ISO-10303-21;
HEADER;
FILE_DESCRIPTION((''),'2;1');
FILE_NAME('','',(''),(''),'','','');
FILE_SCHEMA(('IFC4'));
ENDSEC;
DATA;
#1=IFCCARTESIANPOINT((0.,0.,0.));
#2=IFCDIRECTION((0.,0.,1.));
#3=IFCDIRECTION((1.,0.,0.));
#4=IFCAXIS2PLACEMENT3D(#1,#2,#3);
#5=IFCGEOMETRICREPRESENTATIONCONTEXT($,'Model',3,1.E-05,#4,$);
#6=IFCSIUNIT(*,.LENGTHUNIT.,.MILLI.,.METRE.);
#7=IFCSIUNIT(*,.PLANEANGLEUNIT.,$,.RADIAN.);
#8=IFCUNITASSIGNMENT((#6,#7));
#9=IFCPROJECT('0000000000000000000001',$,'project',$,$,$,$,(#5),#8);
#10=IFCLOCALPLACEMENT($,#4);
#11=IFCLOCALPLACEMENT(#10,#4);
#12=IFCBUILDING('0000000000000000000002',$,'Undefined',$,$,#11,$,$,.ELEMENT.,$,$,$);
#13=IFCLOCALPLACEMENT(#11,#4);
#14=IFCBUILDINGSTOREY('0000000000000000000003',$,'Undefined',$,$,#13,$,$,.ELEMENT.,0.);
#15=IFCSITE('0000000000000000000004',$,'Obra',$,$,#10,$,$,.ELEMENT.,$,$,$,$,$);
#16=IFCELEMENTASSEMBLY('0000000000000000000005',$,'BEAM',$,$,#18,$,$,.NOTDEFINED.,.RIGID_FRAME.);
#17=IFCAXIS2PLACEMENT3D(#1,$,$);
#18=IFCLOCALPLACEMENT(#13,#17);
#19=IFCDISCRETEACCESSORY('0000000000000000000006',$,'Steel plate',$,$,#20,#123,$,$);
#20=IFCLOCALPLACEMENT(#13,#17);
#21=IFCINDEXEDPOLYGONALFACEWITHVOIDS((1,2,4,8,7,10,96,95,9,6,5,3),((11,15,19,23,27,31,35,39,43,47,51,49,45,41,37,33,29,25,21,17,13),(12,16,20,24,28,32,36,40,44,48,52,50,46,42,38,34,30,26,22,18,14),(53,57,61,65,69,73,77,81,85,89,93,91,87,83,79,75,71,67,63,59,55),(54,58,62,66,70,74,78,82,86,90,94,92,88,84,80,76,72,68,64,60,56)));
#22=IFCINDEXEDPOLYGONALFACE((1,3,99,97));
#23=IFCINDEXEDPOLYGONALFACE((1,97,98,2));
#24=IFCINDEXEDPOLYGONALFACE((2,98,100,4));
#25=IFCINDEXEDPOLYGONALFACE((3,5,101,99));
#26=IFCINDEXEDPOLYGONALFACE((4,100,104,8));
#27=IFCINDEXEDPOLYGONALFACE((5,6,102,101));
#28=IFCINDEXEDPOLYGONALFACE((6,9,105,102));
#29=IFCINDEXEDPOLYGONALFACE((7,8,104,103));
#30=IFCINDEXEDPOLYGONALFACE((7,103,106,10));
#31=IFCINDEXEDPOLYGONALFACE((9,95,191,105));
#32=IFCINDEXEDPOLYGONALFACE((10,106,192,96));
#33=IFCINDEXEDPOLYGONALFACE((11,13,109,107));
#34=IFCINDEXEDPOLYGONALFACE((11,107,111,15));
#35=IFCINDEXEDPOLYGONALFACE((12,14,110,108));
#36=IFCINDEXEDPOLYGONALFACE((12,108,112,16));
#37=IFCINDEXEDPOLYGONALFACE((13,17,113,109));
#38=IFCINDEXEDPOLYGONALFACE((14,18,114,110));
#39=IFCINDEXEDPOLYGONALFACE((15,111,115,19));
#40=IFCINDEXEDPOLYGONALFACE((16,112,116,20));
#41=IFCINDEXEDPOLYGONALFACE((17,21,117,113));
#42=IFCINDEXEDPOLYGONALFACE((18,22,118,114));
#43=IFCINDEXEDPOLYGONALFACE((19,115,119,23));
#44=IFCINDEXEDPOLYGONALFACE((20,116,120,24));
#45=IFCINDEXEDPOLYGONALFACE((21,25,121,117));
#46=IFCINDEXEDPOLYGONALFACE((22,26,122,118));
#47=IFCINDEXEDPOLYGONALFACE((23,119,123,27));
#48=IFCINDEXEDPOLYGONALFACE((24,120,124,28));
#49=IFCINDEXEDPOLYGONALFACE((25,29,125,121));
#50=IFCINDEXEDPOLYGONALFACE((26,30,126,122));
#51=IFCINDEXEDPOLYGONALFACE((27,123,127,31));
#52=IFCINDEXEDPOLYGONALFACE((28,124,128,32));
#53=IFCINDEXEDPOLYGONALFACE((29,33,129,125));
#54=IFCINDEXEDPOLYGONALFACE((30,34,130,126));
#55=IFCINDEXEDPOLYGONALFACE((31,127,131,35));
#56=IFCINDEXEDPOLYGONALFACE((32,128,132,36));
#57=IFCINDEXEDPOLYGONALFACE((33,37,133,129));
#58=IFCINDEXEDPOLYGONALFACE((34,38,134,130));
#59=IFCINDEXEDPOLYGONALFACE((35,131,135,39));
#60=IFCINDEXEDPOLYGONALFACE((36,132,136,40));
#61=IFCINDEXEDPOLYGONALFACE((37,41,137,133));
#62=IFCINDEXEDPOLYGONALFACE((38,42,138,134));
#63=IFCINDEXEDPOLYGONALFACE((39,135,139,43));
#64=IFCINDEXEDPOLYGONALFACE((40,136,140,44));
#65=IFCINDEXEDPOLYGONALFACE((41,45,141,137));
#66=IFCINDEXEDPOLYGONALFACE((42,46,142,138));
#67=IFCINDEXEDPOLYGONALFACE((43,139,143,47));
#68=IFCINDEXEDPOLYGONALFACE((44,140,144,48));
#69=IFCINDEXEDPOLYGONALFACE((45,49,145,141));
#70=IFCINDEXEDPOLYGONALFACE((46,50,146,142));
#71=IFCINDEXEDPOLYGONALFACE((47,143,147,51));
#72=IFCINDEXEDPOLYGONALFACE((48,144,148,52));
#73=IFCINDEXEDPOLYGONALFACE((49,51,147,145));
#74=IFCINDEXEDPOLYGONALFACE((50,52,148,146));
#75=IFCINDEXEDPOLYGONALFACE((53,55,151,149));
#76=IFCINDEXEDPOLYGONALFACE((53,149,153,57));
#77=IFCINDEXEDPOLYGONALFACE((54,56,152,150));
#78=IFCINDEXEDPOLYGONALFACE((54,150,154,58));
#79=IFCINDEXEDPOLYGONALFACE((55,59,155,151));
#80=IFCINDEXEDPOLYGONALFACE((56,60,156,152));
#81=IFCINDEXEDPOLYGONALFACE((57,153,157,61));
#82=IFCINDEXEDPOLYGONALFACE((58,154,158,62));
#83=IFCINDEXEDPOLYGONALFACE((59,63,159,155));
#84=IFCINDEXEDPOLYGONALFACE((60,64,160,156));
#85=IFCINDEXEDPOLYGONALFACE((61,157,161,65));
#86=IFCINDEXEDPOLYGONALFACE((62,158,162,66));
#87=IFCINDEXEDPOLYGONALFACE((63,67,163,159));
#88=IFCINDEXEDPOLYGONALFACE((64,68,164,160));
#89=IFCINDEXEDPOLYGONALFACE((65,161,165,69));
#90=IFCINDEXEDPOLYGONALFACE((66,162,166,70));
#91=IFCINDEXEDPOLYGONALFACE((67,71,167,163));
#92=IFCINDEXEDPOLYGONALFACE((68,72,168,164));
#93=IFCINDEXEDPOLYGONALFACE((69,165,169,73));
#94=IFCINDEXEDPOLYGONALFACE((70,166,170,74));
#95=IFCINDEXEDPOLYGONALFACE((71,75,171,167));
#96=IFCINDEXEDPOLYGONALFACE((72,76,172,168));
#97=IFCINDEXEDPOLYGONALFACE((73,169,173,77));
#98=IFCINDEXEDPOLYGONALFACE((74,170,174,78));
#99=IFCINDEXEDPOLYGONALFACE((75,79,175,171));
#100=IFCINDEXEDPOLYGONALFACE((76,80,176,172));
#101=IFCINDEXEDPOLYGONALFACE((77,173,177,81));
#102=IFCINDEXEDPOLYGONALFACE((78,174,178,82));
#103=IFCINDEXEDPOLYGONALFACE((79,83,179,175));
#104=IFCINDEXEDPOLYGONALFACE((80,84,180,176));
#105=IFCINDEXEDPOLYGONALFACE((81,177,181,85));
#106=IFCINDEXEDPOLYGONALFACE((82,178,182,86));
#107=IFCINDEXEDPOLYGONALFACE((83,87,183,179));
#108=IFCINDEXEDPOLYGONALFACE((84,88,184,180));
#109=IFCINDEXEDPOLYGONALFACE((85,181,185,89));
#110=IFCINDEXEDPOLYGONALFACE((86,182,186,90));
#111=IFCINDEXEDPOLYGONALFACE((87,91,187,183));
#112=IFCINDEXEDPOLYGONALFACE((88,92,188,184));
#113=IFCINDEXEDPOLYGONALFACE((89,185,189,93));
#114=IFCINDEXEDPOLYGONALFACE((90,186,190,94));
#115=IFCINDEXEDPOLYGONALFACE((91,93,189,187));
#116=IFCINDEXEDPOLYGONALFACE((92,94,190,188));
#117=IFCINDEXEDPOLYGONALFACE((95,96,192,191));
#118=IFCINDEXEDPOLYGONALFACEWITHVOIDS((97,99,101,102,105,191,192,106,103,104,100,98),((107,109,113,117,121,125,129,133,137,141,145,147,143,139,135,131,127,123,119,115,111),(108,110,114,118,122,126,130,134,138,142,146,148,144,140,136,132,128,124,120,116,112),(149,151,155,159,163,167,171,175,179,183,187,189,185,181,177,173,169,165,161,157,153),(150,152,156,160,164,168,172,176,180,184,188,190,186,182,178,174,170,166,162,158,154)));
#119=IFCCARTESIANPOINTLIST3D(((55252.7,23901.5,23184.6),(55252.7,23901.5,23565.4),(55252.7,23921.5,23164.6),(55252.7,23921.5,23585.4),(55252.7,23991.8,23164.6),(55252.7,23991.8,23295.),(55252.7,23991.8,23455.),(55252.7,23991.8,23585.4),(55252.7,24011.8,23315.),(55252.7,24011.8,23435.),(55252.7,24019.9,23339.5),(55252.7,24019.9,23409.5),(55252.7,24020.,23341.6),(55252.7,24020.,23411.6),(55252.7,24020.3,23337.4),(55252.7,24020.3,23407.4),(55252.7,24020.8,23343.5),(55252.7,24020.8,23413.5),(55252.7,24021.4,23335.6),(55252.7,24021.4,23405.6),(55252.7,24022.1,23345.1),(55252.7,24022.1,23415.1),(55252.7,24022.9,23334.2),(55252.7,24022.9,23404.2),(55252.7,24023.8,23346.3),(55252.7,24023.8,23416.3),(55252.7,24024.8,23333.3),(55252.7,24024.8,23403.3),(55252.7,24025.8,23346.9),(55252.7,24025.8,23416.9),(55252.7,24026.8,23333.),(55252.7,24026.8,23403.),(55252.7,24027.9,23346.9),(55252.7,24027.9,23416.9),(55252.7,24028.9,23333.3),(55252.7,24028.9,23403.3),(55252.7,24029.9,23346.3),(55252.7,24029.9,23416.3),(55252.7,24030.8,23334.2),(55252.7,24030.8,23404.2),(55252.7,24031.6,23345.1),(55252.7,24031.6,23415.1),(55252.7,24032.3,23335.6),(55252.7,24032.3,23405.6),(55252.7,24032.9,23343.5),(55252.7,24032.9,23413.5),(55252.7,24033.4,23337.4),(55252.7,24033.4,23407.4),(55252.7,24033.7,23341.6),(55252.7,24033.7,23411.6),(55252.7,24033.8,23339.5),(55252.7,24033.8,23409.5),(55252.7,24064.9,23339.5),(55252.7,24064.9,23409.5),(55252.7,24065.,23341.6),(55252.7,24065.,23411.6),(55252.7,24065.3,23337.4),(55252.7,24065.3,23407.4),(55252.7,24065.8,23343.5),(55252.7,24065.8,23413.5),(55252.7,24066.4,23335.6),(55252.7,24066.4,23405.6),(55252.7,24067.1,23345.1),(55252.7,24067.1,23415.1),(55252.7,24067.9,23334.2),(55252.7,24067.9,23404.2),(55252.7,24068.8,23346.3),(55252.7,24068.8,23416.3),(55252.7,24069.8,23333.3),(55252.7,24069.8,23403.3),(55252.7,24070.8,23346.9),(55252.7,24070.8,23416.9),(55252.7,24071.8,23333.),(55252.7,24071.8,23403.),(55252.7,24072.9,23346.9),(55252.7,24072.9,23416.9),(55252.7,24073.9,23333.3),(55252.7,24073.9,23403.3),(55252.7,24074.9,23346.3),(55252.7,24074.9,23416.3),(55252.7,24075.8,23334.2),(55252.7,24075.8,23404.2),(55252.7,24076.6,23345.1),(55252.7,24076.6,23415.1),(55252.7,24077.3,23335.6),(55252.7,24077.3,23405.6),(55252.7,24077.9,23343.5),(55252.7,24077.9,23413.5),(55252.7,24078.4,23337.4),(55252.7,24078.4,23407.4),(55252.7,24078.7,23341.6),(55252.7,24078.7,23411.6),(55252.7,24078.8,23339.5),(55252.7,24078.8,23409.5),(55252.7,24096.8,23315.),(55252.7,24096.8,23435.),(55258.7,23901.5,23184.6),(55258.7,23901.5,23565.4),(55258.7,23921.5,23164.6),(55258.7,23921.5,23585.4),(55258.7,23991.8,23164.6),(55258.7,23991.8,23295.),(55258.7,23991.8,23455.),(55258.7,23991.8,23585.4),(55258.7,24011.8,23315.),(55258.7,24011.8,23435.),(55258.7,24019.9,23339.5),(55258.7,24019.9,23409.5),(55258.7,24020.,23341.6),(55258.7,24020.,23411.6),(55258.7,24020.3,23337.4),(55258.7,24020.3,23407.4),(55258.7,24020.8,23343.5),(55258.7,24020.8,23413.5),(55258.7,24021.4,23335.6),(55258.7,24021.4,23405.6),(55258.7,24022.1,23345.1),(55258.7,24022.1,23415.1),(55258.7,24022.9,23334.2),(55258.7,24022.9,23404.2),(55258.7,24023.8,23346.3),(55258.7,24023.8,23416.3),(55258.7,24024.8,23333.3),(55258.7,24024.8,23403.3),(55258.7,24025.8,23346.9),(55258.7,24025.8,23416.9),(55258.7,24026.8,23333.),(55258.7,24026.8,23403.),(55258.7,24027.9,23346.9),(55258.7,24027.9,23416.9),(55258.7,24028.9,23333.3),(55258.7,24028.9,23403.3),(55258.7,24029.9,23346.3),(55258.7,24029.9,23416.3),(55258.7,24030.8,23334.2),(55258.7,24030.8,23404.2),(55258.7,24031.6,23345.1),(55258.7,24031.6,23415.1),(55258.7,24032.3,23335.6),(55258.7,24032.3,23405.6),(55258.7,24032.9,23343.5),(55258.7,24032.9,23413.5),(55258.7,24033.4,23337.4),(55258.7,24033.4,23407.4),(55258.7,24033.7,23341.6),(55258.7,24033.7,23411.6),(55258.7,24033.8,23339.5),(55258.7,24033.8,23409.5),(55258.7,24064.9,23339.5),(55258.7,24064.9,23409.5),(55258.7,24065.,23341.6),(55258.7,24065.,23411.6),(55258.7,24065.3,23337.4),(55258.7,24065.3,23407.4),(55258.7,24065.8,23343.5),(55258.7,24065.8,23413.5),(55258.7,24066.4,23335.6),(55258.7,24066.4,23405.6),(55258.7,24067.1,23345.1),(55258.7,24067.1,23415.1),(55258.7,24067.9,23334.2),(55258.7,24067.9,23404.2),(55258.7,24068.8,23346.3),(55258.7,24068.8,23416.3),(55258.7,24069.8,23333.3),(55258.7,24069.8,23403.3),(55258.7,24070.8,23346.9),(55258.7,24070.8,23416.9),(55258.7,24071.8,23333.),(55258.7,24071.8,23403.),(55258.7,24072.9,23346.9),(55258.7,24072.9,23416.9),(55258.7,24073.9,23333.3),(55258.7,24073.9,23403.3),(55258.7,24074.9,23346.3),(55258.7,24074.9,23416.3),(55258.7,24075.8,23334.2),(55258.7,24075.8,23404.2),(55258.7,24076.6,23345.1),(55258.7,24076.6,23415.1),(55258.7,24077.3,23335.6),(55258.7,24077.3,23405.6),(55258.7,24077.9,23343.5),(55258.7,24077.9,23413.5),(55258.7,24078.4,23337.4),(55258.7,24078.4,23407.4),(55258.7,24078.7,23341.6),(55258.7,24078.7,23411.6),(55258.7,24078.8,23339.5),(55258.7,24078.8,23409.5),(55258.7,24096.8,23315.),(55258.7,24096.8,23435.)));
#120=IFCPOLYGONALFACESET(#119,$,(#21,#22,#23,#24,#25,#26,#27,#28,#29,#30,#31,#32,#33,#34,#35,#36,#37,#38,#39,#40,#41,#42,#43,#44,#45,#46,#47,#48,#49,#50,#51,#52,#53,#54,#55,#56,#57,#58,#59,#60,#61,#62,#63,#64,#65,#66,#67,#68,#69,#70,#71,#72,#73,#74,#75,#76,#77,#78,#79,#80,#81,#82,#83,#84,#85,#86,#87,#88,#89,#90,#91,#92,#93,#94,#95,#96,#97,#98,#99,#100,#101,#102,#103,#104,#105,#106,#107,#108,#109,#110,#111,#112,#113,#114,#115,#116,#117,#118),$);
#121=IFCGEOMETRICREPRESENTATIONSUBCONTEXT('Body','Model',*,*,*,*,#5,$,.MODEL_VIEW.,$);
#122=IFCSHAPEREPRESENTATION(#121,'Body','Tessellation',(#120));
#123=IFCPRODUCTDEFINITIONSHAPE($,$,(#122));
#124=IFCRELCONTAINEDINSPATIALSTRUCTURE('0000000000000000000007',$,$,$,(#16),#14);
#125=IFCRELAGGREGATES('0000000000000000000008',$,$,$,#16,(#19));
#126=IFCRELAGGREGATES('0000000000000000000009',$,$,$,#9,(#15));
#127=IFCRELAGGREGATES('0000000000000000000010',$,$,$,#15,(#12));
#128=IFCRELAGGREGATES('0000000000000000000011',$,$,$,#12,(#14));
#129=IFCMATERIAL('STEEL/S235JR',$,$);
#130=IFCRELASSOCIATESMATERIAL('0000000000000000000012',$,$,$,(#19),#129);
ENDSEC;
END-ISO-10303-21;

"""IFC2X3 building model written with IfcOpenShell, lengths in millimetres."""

from ifc_helpers import new_model, si_unit, frame, origin_with_axes, origin_2d_with_axis, place, context, subcontext, project, spatial, polyline, circle, outline, extrude, source, transform, mapped, material, element, aggregate, save


model = new_model("IFC2X3")

# Units and contexts
model_context = context("Model", 3, precision=1e-05, world=origin_with_axes())
body_context = subcontext(model_context, "Body", "Model", "MODEL_VIEW")
ifc_project = project(units=[si_unit("LENGTHUNIT", "METRE", prefix="MILLI"), si_unit("PLANEANGLEUNIT", "RADIAN")], contexts=[model_context])

# Site, building, storey
site_placement = place(None, origin_with_axes())
site = spatial("IfcSite", under=ifc_project, at=site_placement, Name="Obra", CompositionType="ELEMENT")
building_placement = place(site_placement, origin_with_axes())
building = spatial("IfcBuilding", under=site, at=building_placement, Name="Undefined", CompositionType="ELEMENT")
storey_placement = place(building_placement, origin_with_axes())
storey = spatial("IfcBuildingStorey", under=building, at=storey_placement, Name="Undefined", CompositionType="ELEMENT", Elevation=0.0)

# Shared definitions
ifc_material_1 = material(Name="STEEL/S235JR")

# Element assembly, discrete accessory, opening
assembly_1_placement = place(storey_placement, origin_with_axes())
assembly_1 = element("IfcElementAssembly", 1, at=assembly_1_placement, inside=storey, Name="BEAM", AssemblyPlace="NOTDEFINED", PredefinedType="RIGID_FRAME")
discrete_accessory_1_placement = place(assembly_1_placement, frame((55255.7, 23901.5, 23184.6), z_axis=(1.0, 0.0, 0.0), x_axis=(-0.000001, 0.707107, -0.707107)))
discrete_accessory_1 = element("IfcDiscreteAccessory", 2, at=discrete_accessory_1_placement, material=ifc_material_1, Name="Steel plate", context=body_context, shape_type="SweptSolid", body=[
    extrude(outline(polyline([(0.0, 0.0), (28.3, 0.0), (78.0, 49.7), (-14.2, 141.9), (-14.2, 170.2), (45.9, 230.3), (-39.0, 315.2), (-99.1, 255.1), (-127.3, 255.1), (-219.6, 347.3), (-269.3, 297.6), (-269.3, 269.3), (0.0, 0.0)])), frame((0.0, 0.0, -3.0), z_axis=(0.0, 0.0, 1.0), x_axis=(1.0, 0.0, 0.0)), (0.0, 0.0, 1.0), 6.0),
])
shared_shape_1 = source(origin_with_axes(), body_context, "Body", "SweptSolid", [
    extrude(circle(Radius=7.0, at=origin_2d_with_axis()), frame((0.0, -8.6, 0.0), z_axis=(0.0, 1.0, 0.0), x_axis=(1.0, 0.0, 0.0)), (0.0, 0.0, 1.0), 6.2),
])
opening_1_placement = place(assembly_1_placement, frame((55250.2, 24001.8, 23435.0), z_axis=(0.0, 1.0, 0.0), x_axis=(0.0, 0.0, -1.0)))
element("IfcOpeningElement", 3, at=opening_1_placement, cuts=discrete_accessory_1, ObjectType="Opening", context=body_context, shape_type="MappedRepresentation", body=[
    mapped(shared_shape_1, transform((25.0, 0.0, 25.0))),
    mapped(shared_shape_1, transform((25.0, 0.0, 70.0))),
    mapped(shared_shape_1, transform((95.0, 0.0, 25.0))),
    mapped(shared_shape_1, transform((95.0, 0.0, 70.0))),
])

aggregate(assembly_1, [discrete_accessory_1])

save(model, "model.ifc")
